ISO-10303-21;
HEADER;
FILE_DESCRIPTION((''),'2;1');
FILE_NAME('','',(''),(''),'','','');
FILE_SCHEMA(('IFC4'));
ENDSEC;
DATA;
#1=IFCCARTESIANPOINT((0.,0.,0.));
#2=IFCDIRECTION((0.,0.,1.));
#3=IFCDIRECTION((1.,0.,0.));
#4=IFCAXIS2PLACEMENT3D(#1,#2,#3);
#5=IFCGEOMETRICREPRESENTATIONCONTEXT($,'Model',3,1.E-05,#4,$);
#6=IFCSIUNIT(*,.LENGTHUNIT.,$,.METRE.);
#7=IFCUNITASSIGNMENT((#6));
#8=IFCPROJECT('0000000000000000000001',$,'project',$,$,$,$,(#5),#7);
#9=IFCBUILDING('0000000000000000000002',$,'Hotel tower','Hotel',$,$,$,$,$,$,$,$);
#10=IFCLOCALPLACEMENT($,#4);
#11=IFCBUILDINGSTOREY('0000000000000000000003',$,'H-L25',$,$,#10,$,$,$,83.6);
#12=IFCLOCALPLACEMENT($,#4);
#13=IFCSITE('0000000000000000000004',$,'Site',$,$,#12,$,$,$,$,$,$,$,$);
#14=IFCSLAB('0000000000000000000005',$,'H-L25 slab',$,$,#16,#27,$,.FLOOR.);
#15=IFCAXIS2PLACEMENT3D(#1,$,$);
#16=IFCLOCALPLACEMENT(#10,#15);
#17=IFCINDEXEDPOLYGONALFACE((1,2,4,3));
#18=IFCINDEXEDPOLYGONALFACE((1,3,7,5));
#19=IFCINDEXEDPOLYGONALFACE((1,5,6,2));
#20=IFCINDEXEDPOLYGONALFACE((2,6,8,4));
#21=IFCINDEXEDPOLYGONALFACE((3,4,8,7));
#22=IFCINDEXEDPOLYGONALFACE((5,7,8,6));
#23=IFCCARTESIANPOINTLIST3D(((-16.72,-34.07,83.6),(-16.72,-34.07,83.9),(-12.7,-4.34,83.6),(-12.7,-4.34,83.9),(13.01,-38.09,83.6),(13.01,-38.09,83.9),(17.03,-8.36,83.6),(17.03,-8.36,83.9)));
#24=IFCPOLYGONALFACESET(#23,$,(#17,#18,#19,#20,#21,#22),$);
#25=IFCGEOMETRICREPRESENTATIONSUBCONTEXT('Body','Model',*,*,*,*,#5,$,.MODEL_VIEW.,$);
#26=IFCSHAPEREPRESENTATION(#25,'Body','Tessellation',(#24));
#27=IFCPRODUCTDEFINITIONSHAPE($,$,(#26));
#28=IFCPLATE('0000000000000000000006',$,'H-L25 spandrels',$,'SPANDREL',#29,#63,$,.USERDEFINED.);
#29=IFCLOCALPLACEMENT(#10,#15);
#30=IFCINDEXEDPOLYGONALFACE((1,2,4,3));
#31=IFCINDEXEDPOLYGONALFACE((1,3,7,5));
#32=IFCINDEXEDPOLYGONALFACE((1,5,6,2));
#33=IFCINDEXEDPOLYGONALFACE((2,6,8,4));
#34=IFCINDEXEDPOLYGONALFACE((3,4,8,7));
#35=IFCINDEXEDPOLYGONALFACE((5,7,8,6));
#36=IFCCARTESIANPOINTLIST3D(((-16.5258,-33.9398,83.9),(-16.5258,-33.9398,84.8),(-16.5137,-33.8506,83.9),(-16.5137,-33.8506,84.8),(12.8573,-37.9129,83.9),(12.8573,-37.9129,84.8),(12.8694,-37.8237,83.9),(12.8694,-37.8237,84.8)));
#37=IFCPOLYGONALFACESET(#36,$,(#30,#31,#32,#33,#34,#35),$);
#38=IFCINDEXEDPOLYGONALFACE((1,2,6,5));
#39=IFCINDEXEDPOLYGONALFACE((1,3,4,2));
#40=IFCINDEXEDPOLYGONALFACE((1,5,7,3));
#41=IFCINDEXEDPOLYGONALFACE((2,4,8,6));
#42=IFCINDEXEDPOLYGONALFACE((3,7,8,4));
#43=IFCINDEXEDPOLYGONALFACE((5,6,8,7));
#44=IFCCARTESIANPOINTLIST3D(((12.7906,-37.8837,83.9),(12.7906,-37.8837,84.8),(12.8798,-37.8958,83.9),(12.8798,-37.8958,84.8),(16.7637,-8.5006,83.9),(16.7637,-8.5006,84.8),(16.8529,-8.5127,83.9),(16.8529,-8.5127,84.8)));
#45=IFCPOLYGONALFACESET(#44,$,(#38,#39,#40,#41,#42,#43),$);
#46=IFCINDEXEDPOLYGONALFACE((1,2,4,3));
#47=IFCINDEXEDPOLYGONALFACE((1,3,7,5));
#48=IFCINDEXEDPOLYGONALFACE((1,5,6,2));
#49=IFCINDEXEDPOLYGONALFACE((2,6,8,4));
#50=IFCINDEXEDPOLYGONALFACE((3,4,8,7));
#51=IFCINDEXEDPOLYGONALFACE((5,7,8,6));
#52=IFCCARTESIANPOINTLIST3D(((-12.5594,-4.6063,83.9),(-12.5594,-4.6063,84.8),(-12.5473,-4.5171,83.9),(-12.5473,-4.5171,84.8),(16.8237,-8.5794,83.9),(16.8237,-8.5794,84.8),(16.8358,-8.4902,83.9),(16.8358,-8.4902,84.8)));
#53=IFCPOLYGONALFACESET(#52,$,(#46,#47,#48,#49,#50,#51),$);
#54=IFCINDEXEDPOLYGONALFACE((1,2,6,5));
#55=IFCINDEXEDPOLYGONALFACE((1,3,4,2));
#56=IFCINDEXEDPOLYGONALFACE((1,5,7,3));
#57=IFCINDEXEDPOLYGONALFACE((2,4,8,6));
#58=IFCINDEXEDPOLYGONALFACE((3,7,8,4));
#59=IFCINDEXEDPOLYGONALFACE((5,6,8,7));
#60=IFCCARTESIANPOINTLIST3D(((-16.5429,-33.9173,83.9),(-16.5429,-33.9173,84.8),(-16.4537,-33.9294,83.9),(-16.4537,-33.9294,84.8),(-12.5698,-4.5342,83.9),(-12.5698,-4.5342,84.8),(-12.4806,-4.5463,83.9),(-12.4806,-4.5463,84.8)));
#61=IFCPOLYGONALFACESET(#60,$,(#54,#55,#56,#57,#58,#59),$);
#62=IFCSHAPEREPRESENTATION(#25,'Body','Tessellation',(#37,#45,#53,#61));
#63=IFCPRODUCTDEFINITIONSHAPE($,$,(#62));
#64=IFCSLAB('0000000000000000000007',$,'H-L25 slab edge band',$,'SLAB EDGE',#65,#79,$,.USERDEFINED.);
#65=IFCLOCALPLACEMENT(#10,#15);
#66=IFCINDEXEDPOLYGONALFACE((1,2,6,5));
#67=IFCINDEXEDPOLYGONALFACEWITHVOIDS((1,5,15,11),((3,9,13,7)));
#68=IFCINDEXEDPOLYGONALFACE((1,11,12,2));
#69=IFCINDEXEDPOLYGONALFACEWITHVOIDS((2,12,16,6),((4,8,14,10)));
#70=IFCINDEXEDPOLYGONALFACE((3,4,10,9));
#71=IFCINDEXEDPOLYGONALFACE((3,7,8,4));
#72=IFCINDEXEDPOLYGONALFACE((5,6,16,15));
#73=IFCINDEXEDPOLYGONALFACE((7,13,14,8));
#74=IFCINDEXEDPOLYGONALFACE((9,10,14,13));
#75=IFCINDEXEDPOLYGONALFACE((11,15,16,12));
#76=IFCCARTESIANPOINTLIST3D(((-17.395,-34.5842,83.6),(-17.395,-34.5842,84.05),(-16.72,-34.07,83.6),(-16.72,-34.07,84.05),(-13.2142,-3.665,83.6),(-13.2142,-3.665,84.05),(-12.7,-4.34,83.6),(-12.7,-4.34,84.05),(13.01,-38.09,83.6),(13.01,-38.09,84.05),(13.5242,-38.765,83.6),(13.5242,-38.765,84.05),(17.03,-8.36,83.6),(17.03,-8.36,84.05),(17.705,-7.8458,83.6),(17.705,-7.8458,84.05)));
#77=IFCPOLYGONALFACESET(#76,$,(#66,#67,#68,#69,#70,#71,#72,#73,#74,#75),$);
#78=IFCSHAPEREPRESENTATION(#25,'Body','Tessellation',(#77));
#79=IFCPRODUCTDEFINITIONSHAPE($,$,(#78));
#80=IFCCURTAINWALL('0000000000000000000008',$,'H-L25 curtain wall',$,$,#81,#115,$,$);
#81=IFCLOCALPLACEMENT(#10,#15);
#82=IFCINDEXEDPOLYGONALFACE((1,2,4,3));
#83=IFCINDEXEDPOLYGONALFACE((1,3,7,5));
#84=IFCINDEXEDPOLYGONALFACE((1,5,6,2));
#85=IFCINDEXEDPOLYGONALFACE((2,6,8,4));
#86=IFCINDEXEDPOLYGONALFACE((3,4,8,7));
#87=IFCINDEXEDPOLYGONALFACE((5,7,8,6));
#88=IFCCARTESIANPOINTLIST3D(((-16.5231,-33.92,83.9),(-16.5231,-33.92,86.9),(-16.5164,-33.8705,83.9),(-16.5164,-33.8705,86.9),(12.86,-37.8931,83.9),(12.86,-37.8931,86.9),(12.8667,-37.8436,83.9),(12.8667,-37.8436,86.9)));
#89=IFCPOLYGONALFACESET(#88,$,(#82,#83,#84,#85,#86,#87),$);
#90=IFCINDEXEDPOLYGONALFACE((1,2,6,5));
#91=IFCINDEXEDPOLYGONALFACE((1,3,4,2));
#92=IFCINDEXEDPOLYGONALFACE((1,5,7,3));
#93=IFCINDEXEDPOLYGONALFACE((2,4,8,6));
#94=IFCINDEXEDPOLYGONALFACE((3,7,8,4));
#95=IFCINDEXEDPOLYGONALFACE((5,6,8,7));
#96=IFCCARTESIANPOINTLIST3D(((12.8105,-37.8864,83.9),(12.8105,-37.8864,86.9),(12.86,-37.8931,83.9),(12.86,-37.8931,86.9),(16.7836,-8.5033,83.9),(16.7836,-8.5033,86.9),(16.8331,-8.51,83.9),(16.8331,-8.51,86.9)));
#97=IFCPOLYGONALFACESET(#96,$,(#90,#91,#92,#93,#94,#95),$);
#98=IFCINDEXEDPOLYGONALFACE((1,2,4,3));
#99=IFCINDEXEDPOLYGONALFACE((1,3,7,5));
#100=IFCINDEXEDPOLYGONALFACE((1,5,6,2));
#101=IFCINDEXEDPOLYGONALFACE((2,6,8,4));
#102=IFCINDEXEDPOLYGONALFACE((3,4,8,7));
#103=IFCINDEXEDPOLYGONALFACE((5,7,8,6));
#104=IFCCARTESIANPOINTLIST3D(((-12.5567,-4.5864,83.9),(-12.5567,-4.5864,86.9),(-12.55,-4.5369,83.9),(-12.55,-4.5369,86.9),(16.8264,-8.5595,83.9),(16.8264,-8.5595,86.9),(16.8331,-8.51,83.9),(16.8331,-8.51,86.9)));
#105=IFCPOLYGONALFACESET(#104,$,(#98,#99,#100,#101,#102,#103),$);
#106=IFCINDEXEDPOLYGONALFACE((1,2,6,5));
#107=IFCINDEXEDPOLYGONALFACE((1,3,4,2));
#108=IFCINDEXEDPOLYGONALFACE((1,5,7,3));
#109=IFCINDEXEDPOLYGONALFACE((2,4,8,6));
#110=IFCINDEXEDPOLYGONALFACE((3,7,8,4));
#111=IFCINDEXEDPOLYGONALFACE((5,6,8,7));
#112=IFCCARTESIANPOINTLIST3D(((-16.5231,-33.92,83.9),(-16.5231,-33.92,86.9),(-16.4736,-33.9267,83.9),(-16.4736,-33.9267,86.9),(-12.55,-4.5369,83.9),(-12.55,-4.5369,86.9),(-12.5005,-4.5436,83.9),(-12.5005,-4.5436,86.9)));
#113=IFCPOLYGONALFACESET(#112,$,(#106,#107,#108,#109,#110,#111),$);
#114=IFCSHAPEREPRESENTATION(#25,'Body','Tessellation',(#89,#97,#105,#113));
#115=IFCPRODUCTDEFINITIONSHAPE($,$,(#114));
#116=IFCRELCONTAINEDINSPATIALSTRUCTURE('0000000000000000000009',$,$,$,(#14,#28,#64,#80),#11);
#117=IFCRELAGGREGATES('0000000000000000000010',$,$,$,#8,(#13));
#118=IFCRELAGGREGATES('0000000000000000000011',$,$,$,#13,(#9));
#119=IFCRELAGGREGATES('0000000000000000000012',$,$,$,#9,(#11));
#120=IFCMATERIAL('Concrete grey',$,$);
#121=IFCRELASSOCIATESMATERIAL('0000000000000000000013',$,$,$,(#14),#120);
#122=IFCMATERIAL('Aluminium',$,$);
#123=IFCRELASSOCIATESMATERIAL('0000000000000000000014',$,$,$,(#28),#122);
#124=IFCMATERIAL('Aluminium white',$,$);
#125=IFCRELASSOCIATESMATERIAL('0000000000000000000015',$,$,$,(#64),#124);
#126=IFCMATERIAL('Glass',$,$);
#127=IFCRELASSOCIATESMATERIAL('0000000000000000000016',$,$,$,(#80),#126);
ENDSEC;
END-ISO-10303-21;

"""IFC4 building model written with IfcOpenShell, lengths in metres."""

from ifc_helpers import new_model, si_unit, frame, origin_with_axes, place, context, subcontext, project, spatial, polyline, outline, extrude, material, element, save


model = new_model("IFC4")

# Units and contexts
model_context = context("Model", 3, precision=1e-05, world=origin_with_axes())
body_context = subcontext(model_context, "Body", "Model", "MODEL_VIEW")
ifc_project = project(units=[si_unit("LENGTHUNIT", "METRE")], contexts=[model_context])

# Site, building, storey
site_placement = place(None, origin_with_axes())
site = spatial("IfcSite", under=ifc_project, at=site_placement, Name="Site")
building = spatial("IfcBuilding", under=site, Name="Hotel tower", Description="Hotel")
storey_placement = place(None, origin_with_axes())
storey = spatial("IfcBuildingStorey", under=building, at=storey_placement, Name="H-L25", Elevation=83.6)

# Shared definitions
ifc_material_1 = material(Name="Aluminium")

# Slab
ifc_material_2 = material(Name="Concrete grey")
slab_1_placement = place(storey_placement, origin_with_axes())
element("IfcSlab", 1, at=slab_1_placement, inside=storey, material=ifc_material_2, Name="H-L25 slab", PredefinedType="FLOOR", context=body_context, shape_type="SweptSolid", body=[
    extrude(outline(polyline([(-16.72, -34.07), (13.01, -38.09), (17.03, -8.36), (-12.7, -4.34), (-16.72, -34.07)])), frame((0.0, 0.0, 83.6), z_axis=(0.0, 0.0, 1.0), x_axis=(1.0, 0.0, 0.0)), (0.0, 0.0, 1.0), 0.3),
])

# Plate
plate_placement = place(storey_placement, origin_with_axes())
element("IfcPlate", 2, at=plate_placement, inside=storey, material=ifc_material_1, Name="H-L25 spandrels", ObjectType="SPANDREL", PredefinedType="USERDEFINED", context=body_context, shape_type="SweptSolid", body=[
    extrude(outline(polyline([(-16.5258, -33.9398), (12.8573, -37.9129), (12.8694, -37.8237), (-16.5137, -33.8506), (-16.5258, -33.9398)])), frame((0.0, 0.0, 83.9), z_axis=(0.0, 0.0, 1.0), x_axis=(1.0, 0.0, 0.0)), (0.0, 0.0, 1.0), 0.9),
    extrude(outline(polyline([(12.8798, -37.8958), (16.8529, -8.5127), (16.7637, -8.5006), (12.7906, -37.8837), (12.8798, -37.8958)])), frame((0.0, 0.0, 83.9), z_axis=(0.0, 0.0, 1.0), x_axis=(1.0, 0.0, 0.0)), (0.0, 0.0, 1.0), 0.9),
    extrude(outline(polyline([(16.8358, -8.4902), (-12.5473, -4.5171), (-12.5594, -4.6063), (16.8237, -8.5794), (16.8358, -8.4902)])), frame((0.0, 0.0, 83.9), z_axis=(0.0, 0.0, 1.0), x_axis=(1.0, 0.0, 0.0)), (0.0, 0.0, 1.0), 0.9),
    extrude(outline(polyline([(-12.5698, -4.5342), (-16.5429, -33.9173), (-16.4537, -33.9294), (-12.4806, -4.5463), (-12.5698, -4.5342)])), frame((0.0, 0.0, 83.9), z_axis=(0.0, 0.0, 1.0), x_axis=(1.0, 0.0, 0.0)), (0.0, 0.0, 1.0), 0.9),
])

# Slab
ifc_material_3 = material(Name="Aluminium white")
slab_2_placement = place(storey_placement, origin_with_axes())
element("IfcSlab", 3, at=slab_2_placement, inside=storey, material=ifc_material_3, Name="H-L25 slab edge band", ObjectType="SLAB EDGE", PredefinedType="USERDEFINED", context=body_context, shape_type="SweptSolid", body=[
    extrude(outline(polyline([(-17.395, -34.5842), (13.5242, -38.765), (17.705, -7.8458), (-13.2142, -3.665), (-17.395, -34.5842)]), holes=[polyline([(-16.72, -34.07), (13.01, -38.09), (17.03, -8.36), (-12.7, -4.34), (-16.72, -34.07)])]), frame((0.0, 0.0, 83.6), z_axis=(0.0, 0.0, 1.0), x_axis=(1.0, 0.0, 0.0)), (0.0, 0.0, 1.0), 0.45),
])

# Curtain wall
ifc_material_4 = material(Name="Glass")
curtain_wall_placement = place(storey_placement, origin_with_axes())
element("IfcCurtainWall", 4, at=curtain_wall_placement, inside=storey, material=ifc_material_4, Name="H-L25 curtain wall", context=body_context, shape_type="SweptSolid", body=[
    extrude(outline(polyline([(-16.5231, -33.92), (12.86, -37.8931), (12.8667, -37.8436), (-16.5164, -33.8705), (-16.5231, -33.92)])), frame((0.0, 0.0, 83.9), z_axis=(0.0, 0.0, 1.0), x_axis=(1.0, 0.0, 0.0)), (0.0, 0.0, 1.0), 3.0),
    extrude(outline(polyline([(12.86, -37.8931), (16.8331, -8.51), (16.7836, -8.5033), (12.8105, -37.8864), (12.86, -37.8931)])), frame((0.0, 0.0, 83.9), z_axis=(0.0, 0.0, 1.0), x_axis=(1.0, 0.0, 0.0)), (0.0, 0.0, 1.0), 3.0),
    extrude(outline(polyline([(16.8331, -8.51), (-12.55, -4.5369), (-12.5567, -4.5864), (16.8264, -8.5595), (16.8331, -8.51)])), frame((0.0, 0.0, 83.9), z_axis=(0.0, 0.0, 1.0), x_axis=(1.0, 0.0, 0.0)), (0.0, 0.0, 1.0), 3.0),
    extrude(outline(polyline([(-12.55, -4.5369), (-16.5231, -33.92), (-16.4736, -33.9267), (-12.5005, -4.5436), (-12.55, -4.5369)])), frame((0.0, 0.0, 83.9), z_axis=(0.0, 0.0, 1.0), x_axis=(1.0, 0.0, 0.0)), (0.0, 0.0, 1.0), 3.0),
])

save(model, "model.ifc")
